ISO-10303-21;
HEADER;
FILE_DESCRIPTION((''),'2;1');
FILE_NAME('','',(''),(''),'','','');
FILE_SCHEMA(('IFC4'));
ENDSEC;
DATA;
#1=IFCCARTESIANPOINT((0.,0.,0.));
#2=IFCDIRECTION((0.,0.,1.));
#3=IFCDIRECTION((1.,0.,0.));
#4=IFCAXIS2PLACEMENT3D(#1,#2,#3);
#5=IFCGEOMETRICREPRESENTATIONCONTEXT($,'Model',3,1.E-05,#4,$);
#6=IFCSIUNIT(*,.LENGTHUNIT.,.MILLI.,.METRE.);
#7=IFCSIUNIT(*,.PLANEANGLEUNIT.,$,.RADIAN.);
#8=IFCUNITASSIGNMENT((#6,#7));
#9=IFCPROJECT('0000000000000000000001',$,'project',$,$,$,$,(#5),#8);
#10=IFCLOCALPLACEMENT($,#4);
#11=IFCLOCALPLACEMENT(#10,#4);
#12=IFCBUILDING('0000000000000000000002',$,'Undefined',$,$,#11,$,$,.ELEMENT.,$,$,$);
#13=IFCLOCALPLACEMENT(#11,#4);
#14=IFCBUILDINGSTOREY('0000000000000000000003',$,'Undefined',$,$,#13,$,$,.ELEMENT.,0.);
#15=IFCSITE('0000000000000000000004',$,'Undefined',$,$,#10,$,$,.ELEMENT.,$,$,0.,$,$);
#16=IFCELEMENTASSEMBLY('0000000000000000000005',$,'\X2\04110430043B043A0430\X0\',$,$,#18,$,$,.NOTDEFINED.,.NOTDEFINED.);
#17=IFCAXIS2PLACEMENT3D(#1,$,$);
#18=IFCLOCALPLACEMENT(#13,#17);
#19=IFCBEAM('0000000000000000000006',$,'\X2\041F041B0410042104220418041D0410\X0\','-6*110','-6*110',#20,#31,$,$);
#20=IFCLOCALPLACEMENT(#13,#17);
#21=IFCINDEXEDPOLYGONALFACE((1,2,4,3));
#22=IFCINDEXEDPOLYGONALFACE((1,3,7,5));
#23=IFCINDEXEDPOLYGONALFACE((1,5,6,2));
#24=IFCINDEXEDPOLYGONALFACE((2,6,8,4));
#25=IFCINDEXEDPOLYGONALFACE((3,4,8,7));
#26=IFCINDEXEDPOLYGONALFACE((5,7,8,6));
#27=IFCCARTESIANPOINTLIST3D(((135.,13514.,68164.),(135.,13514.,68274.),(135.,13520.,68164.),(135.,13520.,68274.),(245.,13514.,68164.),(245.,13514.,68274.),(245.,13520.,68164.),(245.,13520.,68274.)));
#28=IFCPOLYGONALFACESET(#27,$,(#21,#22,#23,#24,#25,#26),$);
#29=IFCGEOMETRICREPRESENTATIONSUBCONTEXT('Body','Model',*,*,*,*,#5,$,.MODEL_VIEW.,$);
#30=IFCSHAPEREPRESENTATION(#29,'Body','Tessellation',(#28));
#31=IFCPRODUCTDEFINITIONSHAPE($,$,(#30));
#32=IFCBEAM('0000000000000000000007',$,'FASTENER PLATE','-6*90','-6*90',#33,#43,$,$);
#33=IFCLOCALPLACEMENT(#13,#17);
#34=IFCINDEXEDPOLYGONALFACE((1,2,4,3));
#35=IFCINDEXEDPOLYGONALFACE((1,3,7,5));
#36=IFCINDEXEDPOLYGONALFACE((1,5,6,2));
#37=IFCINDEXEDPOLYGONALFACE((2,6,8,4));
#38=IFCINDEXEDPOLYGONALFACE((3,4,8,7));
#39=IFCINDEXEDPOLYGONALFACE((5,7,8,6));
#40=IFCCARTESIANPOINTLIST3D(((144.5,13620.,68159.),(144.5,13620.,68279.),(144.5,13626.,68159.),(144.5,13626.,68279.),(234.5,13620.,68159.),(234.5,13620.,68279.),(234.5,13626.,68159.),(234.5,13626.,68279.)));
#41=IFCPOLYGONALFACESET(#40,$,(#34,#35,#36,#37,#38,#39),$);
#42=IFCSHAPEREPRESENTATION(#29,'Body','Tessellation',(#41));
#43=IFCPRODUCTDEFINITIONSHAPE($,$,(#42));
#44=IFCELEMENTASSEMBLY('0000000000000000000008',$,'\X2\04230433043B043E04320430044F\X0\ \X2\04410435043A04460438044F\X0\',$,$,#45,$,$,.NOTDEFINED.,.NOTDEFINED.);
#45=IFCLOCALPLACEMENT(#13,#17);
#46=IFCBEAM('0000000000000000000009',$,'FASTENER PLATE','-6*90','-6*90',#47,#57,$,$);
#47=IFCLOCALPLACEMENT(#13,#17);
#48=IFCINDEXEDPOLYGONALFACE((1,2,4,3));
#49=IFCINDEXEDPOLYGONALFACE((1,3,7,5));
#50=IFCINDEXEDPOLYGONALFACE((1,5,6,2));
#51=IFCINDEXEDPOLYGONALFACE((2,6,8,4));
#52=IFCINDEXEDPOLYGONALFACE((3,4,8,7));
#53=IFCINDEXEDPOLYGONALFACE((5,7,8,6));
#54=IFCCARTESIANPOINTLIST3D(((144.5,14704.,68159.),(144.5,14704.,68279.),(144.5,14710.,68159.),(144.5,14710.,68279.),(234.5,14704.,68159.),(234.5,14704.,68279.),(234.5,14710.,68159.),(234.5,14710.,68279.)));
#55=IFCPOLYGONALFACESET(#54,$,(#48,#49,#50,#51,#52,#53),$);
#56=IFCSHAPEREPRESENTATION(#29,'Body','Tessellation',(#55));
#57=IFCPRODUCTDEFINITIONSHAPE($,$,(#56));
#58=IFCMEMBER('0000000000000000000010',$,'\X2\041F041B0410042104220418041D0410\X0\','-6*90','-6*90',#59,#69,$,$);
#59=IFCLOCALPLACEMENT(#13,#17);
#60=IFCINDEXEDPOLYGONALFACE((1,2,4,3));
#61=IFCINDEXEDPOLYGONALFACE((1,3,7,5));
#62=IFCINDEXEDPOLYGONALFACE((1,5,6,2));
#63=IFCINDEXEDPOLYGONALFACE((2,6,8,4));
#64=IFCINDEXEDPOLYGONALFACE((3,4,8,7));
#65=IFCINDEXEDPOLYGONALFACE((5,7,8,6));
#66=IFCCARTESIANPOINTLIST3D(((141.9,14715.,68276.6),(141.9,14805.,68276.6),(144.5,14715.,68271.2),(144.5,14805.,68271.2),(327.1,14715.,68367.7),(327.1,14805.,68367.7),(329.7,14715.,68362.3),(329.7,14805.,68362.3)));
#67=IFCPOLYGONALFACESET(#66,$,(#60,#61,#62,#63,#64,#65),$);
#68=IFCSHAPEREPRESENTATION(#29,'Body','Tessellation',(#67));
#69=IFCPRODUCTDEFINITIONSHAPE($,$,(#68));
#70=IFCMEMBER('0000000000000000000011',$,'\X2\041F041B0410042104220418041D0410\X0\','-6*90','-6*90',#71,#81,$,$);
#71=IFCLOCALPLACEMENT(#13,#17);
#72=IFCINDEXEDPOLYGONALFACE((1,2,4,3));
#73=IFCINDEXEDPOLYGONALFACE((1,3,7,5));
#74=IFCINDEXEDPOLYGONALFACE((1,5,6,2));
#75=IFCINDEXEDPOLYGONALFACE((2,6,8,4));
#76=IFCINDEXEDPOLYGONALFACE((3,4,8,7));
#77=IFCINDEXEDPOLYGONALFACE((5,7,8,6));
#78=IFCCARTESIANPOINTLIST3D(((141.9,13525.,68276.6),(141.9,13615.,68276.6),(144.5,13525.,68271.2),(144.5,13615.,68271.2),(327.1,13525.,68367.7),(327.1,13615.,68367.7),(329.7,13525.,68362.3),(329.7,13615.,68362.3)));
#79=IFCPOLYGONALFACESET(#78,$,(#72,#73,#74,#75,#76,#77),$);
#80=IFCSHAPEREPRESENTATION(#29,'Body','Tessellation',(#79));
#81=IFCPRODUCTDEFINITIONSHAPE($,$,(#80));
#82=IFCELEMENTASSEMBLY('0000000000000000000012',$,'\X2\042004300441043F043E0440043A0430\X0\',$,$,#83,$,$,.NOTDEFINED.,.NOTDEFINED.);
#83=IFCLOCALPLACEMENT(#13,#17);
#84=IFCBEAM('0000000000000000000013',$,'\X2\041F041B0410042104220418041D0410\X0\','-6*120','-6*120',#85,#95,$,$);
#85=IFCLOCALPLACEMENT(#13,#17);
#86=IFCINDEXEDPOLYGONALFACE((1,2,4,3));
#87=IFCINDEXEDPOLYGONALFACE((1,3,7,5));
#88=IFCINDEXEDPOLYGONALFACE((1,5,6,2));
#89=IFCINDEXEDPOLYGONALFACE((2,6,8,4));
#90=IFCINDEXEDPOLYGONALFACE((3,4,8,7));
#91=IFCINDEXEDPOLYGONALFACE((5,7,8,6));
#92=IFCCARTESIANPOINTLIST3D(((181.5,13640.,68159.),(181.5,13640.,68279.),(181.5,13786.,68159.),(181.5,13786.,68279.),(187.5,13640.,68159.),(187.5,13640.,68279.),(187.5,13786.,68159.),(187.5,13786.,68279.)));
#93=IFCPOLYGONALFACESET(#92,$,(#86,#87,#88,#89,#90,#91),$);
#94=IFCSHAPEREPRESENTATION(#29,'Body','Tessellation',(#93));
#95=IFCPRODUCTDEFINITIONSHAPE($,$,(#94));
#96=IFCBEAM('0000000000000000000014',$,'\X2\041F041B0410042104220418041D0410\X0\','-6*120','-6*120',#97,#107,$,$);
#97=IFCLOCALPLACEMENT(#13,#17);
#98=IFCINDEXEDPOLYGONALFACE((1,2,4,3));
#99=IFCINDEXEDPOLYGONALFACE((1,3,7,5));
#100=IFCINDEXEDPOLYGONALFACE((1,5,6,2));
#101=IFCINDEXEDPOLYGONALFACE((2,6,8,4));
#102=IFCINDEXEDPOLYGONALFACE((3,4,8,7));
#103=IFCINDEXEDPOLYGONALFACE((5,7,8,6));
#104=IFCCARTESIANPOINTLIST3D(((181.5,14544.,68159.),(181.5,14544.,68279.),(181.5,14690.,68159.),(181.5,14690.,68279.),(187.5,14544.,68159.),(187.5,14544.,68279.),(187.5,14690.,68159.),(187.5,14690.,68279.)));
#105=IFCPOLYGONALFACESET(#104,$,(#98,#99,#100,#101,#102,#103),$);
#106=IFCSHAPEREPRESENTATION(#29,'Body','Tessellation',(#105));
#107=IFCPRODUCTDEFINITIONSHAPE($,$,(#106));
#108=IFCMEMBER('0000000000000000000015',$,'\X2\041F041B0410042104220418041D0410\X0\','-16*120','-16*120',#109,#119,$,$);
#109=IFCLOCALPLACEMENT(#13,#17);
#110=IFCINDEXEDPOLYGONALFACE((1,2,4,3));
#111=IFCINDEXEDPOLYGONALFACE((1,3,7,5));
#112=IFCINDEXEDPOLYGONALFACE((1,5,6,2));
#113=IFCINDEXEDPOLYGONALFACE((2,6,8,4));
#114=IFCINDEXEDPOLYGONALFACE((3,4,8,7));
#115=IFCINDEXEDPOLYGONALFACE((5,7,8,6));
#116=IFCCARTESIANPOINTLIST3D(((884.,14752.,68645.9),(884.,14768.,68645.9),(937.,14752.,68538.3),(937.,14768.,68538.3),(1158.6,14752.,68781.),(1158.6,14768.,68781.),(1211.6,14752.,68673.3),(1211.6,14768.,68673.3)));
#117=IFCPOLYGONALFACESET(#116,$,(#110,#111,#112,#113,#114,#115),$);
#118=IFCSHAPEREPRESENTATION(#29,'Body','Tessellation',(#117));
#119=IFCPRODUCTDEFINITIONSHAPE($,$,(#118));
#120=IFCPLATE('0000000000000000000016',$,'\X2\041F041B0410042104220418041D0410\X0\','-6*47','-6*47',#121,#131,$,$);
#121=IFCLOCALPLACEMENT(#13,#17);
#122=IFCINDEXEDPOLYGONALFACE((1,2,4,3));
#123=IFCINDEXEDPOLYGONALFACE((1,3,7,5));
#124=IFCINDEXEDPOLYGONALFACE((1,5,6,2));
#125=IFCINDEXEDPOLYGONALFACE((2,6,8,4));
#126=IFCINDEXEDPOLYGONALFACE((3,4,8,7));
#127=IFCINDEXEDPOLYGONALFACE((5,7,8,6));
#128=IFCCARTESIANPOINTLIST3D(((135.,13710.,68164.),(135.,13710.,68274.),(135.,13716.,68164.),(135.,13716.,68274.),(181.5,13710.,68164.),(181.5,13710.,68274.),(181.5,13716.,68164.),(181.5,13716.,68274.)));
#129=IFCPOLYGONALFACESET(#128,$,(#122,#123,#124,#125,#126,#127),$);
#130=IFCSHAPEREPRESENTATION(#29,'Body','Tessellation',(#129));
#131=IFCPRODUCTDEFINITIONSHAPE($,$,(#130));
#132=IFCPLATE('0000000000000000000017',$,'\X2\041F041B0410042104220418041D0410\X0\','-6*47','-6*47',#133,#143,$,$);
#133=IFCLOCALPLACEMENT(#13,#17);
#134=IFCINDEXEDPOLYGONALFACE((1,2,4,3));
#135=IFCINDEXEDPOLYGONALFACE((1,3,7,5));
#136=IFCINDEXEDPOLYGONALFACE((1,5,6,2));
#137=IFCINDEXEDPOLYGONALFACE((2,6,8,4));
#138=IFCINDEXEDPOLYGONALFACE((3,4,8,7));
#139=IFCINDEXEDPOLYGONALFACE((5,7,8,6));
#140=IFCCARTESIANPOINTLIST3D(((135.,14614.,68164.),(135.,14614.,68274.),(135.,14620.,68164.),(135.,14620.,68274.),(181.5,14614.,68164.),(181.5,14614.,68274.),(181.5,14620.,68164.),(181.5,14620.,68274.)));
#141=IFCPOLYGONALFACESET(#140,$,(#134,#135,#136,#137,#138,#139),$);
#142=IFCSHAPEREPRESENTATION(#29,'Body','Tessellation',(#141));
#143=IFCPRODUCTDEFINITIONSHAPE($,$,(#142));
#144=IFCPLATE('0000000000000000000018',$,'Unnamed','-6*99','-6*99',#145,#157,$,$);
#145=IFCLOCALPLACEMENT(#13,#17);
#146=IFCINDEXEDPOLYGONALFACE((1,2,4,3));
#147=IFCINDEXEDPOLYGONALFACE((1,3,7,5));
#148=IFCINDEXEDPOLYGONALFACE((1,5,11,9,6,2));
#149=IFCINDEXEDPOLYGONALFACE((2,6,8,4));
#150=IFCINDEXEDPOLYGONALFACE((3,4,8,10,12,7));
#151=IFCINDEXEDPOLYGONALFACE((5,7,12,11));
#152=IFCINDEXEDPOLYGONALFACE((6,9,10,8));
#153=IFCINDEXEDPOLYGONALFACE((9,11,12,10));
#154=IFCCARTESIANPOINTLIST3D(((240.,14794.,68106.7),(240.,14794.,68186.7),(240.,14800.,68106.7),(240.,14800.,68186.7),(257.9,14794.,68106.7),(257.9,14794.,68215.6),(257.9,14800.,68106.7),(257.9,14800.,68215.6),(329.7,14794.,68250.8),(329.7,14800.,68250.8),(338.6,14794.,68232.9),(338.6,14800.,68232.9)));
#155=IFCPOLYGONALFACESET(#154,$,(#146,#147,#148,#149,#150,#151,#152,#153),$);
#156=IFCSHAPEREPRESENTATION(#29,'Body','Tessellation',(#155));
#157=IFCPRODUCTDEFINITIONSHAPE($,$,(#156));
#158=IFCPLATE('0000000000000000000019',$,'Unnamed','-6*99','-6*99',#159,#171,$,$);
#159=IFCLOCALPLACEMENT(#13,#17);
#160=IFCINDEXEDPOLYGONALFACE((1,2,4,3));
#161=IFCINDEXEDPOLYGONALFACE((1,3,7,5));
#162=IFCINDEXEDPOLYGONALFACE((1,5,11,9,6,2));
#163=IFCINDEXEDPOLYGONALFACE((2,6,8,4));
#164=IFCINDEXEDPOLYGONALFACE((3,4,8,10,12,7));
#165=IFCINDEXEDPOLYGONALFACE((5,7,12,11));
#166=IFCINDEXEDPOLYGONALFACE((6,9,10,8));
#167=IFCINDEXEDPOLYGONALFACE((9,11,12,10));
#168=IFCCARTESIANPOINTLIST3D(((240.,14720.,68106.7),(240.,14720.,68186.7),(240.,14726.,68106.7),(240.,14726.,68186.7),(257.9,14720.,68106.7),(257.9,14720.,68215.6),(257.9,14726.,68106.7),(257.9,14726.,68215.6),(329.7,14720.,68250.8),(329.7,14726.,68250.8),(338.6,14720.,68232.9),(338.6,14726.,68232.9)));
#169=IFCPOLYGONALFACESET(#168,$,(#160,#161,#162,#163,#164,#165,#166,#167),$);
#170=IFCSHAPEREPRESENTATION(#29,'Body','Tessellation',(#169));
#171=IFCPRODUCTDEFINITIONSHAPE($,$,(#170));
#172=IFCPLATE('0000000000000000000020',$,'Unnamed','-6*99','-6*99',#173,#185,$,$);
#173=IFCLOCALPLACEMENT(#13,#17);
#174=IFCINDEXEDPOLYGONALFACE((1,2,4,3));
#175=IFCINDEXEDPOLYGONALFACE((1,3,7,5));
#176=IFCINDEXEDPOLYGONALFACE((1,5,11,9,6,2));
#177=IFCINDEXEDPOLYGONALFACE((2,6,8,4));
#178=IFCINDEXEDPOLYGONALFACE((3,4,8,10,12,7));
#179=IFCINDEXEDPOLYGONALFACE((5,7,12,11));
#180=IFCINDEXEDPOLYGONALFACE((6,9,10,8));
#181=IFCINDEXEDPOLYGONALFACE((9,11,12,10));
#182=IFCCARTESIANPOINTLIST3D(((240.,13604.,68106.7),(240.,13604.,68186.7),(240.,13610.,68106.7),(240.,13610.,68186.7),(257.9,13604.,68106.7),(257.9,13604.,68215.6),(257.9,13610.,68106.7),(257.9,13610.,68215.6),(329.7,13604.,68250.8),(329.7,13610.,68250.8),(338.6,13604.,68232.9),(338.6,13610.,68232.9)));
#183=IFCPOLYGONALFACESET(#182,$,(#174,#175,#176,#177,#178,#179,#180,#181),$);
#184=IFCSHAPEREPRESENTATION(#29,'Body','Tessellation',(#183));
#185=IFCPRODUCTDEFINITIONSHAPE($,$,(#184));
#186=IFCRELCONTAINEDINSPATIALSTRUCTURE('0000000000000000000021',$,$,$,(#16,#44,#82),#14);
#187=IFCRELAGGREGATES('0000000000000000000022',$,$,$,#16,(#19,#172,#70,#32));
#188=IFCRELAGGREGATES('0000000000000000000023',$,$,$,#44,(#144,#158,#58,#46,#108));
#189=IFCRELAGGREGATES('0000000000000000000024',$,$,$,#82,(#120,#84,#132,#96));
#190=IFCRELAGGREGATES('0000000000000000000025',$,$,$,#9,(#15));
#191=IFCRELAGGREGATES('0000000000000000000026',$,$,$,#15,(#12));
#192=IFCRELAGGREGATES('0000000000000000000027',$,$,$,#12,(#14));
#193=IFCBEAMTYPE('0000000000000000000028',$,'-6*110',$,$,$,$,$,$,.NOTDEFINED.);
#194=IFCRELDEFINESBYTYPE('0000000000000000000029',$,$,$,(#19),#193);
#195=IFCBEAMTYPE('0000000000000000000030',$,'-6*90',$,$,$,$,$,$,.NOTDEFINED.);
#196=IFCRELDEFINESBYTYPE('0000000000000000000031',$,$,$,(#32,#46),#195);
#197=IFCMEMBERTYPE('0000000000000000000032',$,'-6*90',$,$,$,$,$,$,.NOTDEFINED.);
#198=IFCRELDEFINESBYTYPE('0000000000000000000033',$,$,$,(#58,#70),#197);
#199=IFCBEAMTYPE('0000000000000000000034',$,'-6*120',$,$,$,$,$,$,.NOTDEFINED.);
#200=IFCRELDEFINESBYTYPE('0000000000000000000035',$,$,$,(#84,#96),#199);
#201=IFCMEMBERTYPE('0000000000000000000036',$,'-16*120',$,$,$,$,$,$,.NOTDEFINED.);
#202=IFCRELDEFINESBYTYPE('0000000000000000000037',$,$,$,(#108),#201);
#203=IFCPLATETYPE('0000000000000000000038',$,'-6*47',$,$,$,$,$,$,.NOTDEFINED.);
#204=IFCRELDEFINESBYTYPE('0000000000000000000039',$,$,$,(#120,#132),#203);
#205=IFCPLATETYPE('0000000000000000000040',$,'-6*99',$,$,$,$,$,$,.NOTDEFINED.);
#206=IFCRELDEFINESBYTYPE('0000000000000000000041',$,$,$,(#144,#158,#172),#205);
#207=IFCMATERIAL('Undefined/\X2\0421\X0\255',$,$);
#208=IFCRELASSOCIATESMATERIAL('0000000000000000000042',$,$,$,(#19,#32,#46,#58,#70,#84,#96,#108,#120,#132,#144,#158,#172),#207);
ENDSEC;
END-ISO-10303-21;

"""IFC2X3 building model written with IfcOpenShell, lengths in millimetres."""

from ifc_helpers import new_model, si_unit, frame, origin_with_axes, origin_2d_with_axis, place, context, subcontext, project, spatial, polyline, rectangle, outline, extrude, material, type_object, element, aggregate, save


model = new_model("IFC2X3")

# Units and contexts
model_context = context("Model", 3, precision=1e-05, world=origin_with_axes())
body_context = subcontext(model_context, "Body", "Model", "MODEL_VIEW")
ifc_project = project(units=[si_unit("LENGTHUNIT", "METRE", prefix="MILLI"), si_unit("PLANEANGLEUNIT", "RADIAN")], contexts=[model_context])

# Site, building, storey
site_placement = place(None, origin_with_axes())
site = spatial("IfcSite", under=ifc_project, at=site_placement, Name="Undefined", CompositionType="ELEMENT", RefElevation=0.0)
building_placement = place(site_placement, origin_with_axes())
building = spatial("IfcBuilding", under=site, at=building_placement, Name="Undefined", CompositionType="ELEMENT")
storey_placement = place(building_placement, origin_with_axes())
storey = spatial("IfcBuildingStorey", under=building, at=storey_placement, Name="Undefined", CompositionType="ELEMENT", Elevation=0.0)

# Element assembly, beams
assembly_1_placement = place(storey_placement, origin_with_axes())
assembly_1 = element("IfcElementAssembly", 1, at=assembly_1_placement, inside=storey, Name="Балка", AssemblyPlace="NOTDEFINED", PredefinedType="NOTDEFINED")
ifc_material_1 = material(Name="Undefined/С255")
beam_type_1 = type_object("IfcBeamType", Name="-6*110", PredefinedType="NOTDEFINED")
beam_1_placement = place(assembly_1_placement, frame((245.0, 13517.0, 68219.0), z_axis=(0.0, 0.0, -1.0), x_axis=(-1.0, 0.0, 0.0)))
beam_1 = element("IfcBeam", 2, at=beam_1_placement, type_object=beam_type_1, material=ifc_material_1, Name="ПЛАСТИНА", Description="-6*110", ObjectType="-6*110", context=body_context, shape_type="SweptSolid", body=[
    extrude(rectangle(XDim=6.0, YDim=110.0, at=origin_2d_with_axis()), frame((110.0, 0.0, 0.0), z_axis=(-1.0, 0.0, 0.0), x_axis=(0.0, -1.0, 0.0)), (0.0, 0.0, 1.0), 110.0),
])
beam_type_2 = type_object("IfcBeamType", Name="-6*90", PredefinedType="NOTDEFINED")
beam_2_placement = place(assembly_1_placement, frame((189.5, 13623.0, 68279.0), z_axis=(1.0, 0.0, 0.0), x_axis=(0.0, 0.0, -1.0)))
beam_2 = element("IfcBeam", 3, at=beam_2_placement, type_object=beam_type_2, material=ifc_material_1, Name="FASTENER PLATE", Description="-6*90", ObjectType="-6*90", context=body_context, shape_type="SweptSolid", body=[
    extrude(rectangle(XDim=6.0, YDim=90.0, at=origin_2d_with_axis()), frame((120.0, 0.0, 0.0), z_axis=(-1.0, 0.0, 0.0), x_axis=(0.0, -1.0, 0.0)), (0.0, 0.0, 1.0), 120.0),
])

# Element assembly, beam, member
assembly_2_placement = place(storey_placement, origin_with_axes())
assembly_2 = element("IfcElementAssembly", 4, at=assembly_2_placement, inside=storey, Name="Угловая секция", AssemblyPlace="NOTDEFINED", PredefinedType="NOTDEFINED")
beam_3_placement = place(assembly_2_placement, frame((189.5, 14707.0, 68159.0), z_axis=(1.0, 0.0, 0.0), x_axis=(0.0, 0.0, 1.0)))
beam_3 = element("IfcBeam", 5, at=beam_3_placement, type_object=beam_type_2, material=ifc_material_1, Name="FASTENER PLATE", Description="-6*90", ObjectType="-6*90", context=body_context, shape_type="SweptSolid", body=[
    extrude(rectangle(XDim=6.0, YDim=90.0, at=origin_2d_with_axis()), frame((120.0, 0.0, 0.0), z_axis=(-1.0, 0.0, 0.0), x_axis=(0.0, -1.0, 0.0)), (0.0, 0.0, 1.0), 120.0),
])
member_type_1 = type_object("IfcMemberType", Name="-6*90", PredefinedType="NOTDEFINED")
member_1_placement = place(assembly_2_placement, frame((143.2, 14760.0, 68273.9), z_axis=(0.0, -1.0, 0.0), x_axis=(0.897399, 0.0, 0.441221)))
member_1 = element("IfcMember", 6, at=member_1_placement, type_object=member_type_1, material=ifc_material_1, Name="ПЛАСТИНА", Description="-6*90", ObjectType="-6*90", context=body_context, shape_type="SweptSolid", body=[
    extrude(rectangle(XDim=6.0, YDim=90.0, at=origin_2d_with_axis()), frame((206.4, 0.0, 0.0), z_axis=(-1.0, 0.0, 0.0), x_axis=(0.0, -1.0, 0.0)), (0.0, 0.0, 1.0), 206.4),
])

# Member
member_2_placement = place(assembly_1_placement, frame((143.2, 13570.0, 68273.9), z_axis=(0.0, -1.0, 0.0), x_axis=(0.897399, 0.0, 0.441221)))
member_2 = element("IfcMember", 7, at=member_2_placement, type_object=member_type_1, material=ifc_material_1, Name="ПЛАСТИНА", Description="-6*90", ObjectType="-6*90", context=body_context, shape_type="SweptSolid", body=[
    extrude(rectangle(XDim=6.0, YDim=90.0, at=origin_2d_with_axis()), frame((206.4, 0.0, 0.0), z_axis=(-1.0, 0.0, 0.0), x_axis=(0.0, -1.0, 0.0)), (0.0, 0.0, 1.0), 206.4),
])

# Element assembly, beams
assembly_3_placement = place(storey_placement, origin_with_axes())
assembly_3 = element("IfcElementAssembly", 8, at=assembly_3_placement, inside=storey, Name="Распорка", AssemblyPlace="NOTDEFINED", PredefinedType="NOTDEFINED")
beam_type_3 = type_object("IfcBeamType", Name="-6*120", PredefinedType="NOTDEFINED")
beam_4_placement = place(assembly_3_placement, frame((184.5, 13640.0, 68219.0), z_axis=(0.0, 0.0, -1.0), x_axis=(0.0, 1.0, 0.0)))
beam_4 = element("IfcBeam", 9, at=beam_4_placement, type_object=beam_type_3, material=ifc_material_1, Name="ПЛАСТИНА", Description="-6*120", ObjectType="-6*120", context=body_context, shape_type="SweptSolid", body=[
    extrude(rectangle(XDim=6.0, YDim=120.0, at=origin_2d_with_axis()), frame((146.0, 0.0, 0.0), z_axis=(-1.0, 0.0, 0.0), x_axis=(0.0, -1.0, 0.0)), (0.0, 0.0, 1.0), 146.0),
])
beam_5_placement = place(assembly_3_placement, frame((184.5, 14690.0, 68219.0), z_axis=(0.0, 0.0, 1.0), x_axis=(0.0, -1.0, 0.0)))
beam_5 = element("IfcBeam", 10, at=beam_5_placement, type_object=beam_type_3, material=ifc_material_1, Name="ПЛАСТИНА", Description="-6*120", ObjectType="-6*120", context=body_context, shape_type="SweptSolid", body=[
    extrude(rectangle(XDim=6.0, YDim=120.0, at=origin_2d_with_axis()), frame((146.0, 0.0, 0.0), z_axis=(-1.0, 0.0, 0.0), x_axis=(0.0, -1.0, 0.0)), (0.0, 0.0, 1.0), 146.0),
])

# Member
member_type_2 = type_object("IfcMemberType", Name="-16*120", PredefinedType="NOTDEFINED")
member_3_placement = place(assembly_2_placement, frame((910.5, 14760.0, 68592.1), z_axis=(0.441221, 0.0, -0.897399), x_axis=(0.897399, 0.0, 0.441221)))
member_3 = element("IfcMember", 11, at=member_3_placement, type_object=member_type_2, material=ifc_material_1, Name="ПЛАСТИНА", Description="-16*120", ObjectType="-16*120", context=body_context, shape_type="SweptSolid", body=[
    extrude(rectangle(XDim=16.0, YDim=120.0, at=origin_2d_with_axis()), frame((306.0, 0.0, 0.0), z_axis=(-1.0, 0.0, 0.0), x_axis=(0.0, -1.0, 0.0)), (0.0, 0.0, 1.0), 306.0),
])

# Plates
plate_type_1 = type_object("IfcPlateType", Name="-6*47", PredefinedType="NOTDEFINED")
plate_1_placement = place(assembly_3_placement, frame((181.5, 13713.0, 68164.0), z_axis=(0.0, 1.0, 0.0), x_axis=(-1.0, 0.0, 0.0)))
plate_1 = element("IfcPlate", 12, at=plate_1_placement, type_object=plate_type_1, material=ifc_material_1, Name="ПЛАСТИНА", Description="-6*47", ObjectType="-6*47", context=body_context, shape_type="SweptSolid", body=[
    extrude(outline(polyline([(0.0, 0.0), (46.5, 0.0), (46.5, 110.0), (0.0, 110.0), (0.0, 0.0)])), frame((0.0, 0.0, -3.0), z_axis=(0.0, 0.0, 1.0), x_axis=(1.0, 0.0, 0.0)), (0.0, 0.0, 1.0), 6.0),
])
plate_2_placement = place(assembly_3_placement, frame((181.5, 14617.0, 68274.0), z_axis=(0.0, -1.0, 0.0), x_axis=(-1.0, 0.0, 0.0)))
plate_2 = element("IfcPlate", 13, at=plate_2_placement, type_object=plate_type_1, material=ifc_material_1, Name="ПЛАСТИНА", Description="-6*47", ObjectType="-6*47", context=body_context, shape_type="SweptSolid", body=[
    extrude(outline(polyline([(0.0, 0.0), (46.5, 0.0), (46.5, 110.0), (0.0, 110.0), (0.0, 0.0)])), frame((0.0, 0.0, -3.0), z_axis=(0.0, 0.0, 1.0), x_axis=(1.0, 0.0, 0.0)), (0.0, 0.0, 1.0), 6.0),
])
plate_type_2 = type_object("IfcPlateType", Name="-6*99", PredefinedType="NOTDEFINED")
plate_3_placement = place(assembly_2_placement, frame((240.0, 14797.0, 68106.7), z_axis=(0.0, 1.0, 0.0), x_axis=(0.0, 0.0, 1.0)))
plate_3 = element("IfcPlate", 14, at=plate_3_placement, type_object=plate_type_2, material=ifc_material_1, Name="Unnamed", Description="-6*99", ObjectType="-6*99", context=body_context, shape_type="SweptSolid", body=[
    extrude(outline(polyline([(0.0, 0.0), (80.0, 0.0), (108.8, 17.9), (144.1, 89.7), (126.2, 98.6), (0.0, 17.9), (0.0, 0.0)])), frame((0.0, 0.0, -3.0), z_axis=(0.0, 0.0, 1.0), x_axis=(1.0, 0.0, 0.0)), (0.0, 0.0, 1.0), 6.0),
])
plate_4_placement = place(assembly_2_placement, frame((240.0, 14723.0, 68106.7), z_axis=(0.0, 1.0, 0.0), x_axis=(0.0, 0.0, 1.0)))
plate_4 = element("IfcPlate", 15, at=plate_4_placement, type_object=plate_type_2, material=ifc_material_1, Name="Unnamed", Description="-6*99", ObjectType="-6*99", context=body_context, shape_type="SweptSolid", body=[
    extrude(outline(polyline([(0.0, 0.0), (80.0, 0.0), (108.8, 17.9), (144.1, 89.7), (126.2, 98.6), (0.0, 17.9), (0.0, 0.0)])), frame((0.0, 0.0, -3.0), z_axis=(0.0, 0.0, 1.0), x_axis=(1.0, 0.0, 0.0)), (0.0, 0.0, 1.0), 6.0),
])
plate_5_placement = place(assembly_1_placement, frame((240.0, 13607.0, 68106.7), z_axis=(0.0, 1.0, 0.0), x_axis=(0.0, 0.0, 1.0)))
plate_5 = element("IfcPlate", 16, at=plate_5_placement, type_object=plate_type_2, material=ifc_material_1, Name="Unnamed", Description="-6*99", ObjectType="-6*99", context=body_context, shape_type="SweptSolid", body=[
    extrude(outline(polyline([(0.0, 0.0), (80.0, 0.0), (108.8, 17.9), (144.1, 89.7), (126.2, 98.6), (0.0, 17.9), (0.0, 0.0)])), frame((0.0, 0.0, -3.0), z_axis=(0.0, 0.0, 1.0), x_axis=(1.0, 0.0, 0.0)), (0.0, 0.0, 1.0), 6.0),
])
aggregate(assembly_1, [beam_1, plate_5, member_2, beam_2])
aggregate(assembly_2, [plate_3, plate_4, member_1, beam_3, member_3])

aggregate(assembly_3, [plate_1, beam_4, plate_2, beam_5])

save(model, "model.ifc")
